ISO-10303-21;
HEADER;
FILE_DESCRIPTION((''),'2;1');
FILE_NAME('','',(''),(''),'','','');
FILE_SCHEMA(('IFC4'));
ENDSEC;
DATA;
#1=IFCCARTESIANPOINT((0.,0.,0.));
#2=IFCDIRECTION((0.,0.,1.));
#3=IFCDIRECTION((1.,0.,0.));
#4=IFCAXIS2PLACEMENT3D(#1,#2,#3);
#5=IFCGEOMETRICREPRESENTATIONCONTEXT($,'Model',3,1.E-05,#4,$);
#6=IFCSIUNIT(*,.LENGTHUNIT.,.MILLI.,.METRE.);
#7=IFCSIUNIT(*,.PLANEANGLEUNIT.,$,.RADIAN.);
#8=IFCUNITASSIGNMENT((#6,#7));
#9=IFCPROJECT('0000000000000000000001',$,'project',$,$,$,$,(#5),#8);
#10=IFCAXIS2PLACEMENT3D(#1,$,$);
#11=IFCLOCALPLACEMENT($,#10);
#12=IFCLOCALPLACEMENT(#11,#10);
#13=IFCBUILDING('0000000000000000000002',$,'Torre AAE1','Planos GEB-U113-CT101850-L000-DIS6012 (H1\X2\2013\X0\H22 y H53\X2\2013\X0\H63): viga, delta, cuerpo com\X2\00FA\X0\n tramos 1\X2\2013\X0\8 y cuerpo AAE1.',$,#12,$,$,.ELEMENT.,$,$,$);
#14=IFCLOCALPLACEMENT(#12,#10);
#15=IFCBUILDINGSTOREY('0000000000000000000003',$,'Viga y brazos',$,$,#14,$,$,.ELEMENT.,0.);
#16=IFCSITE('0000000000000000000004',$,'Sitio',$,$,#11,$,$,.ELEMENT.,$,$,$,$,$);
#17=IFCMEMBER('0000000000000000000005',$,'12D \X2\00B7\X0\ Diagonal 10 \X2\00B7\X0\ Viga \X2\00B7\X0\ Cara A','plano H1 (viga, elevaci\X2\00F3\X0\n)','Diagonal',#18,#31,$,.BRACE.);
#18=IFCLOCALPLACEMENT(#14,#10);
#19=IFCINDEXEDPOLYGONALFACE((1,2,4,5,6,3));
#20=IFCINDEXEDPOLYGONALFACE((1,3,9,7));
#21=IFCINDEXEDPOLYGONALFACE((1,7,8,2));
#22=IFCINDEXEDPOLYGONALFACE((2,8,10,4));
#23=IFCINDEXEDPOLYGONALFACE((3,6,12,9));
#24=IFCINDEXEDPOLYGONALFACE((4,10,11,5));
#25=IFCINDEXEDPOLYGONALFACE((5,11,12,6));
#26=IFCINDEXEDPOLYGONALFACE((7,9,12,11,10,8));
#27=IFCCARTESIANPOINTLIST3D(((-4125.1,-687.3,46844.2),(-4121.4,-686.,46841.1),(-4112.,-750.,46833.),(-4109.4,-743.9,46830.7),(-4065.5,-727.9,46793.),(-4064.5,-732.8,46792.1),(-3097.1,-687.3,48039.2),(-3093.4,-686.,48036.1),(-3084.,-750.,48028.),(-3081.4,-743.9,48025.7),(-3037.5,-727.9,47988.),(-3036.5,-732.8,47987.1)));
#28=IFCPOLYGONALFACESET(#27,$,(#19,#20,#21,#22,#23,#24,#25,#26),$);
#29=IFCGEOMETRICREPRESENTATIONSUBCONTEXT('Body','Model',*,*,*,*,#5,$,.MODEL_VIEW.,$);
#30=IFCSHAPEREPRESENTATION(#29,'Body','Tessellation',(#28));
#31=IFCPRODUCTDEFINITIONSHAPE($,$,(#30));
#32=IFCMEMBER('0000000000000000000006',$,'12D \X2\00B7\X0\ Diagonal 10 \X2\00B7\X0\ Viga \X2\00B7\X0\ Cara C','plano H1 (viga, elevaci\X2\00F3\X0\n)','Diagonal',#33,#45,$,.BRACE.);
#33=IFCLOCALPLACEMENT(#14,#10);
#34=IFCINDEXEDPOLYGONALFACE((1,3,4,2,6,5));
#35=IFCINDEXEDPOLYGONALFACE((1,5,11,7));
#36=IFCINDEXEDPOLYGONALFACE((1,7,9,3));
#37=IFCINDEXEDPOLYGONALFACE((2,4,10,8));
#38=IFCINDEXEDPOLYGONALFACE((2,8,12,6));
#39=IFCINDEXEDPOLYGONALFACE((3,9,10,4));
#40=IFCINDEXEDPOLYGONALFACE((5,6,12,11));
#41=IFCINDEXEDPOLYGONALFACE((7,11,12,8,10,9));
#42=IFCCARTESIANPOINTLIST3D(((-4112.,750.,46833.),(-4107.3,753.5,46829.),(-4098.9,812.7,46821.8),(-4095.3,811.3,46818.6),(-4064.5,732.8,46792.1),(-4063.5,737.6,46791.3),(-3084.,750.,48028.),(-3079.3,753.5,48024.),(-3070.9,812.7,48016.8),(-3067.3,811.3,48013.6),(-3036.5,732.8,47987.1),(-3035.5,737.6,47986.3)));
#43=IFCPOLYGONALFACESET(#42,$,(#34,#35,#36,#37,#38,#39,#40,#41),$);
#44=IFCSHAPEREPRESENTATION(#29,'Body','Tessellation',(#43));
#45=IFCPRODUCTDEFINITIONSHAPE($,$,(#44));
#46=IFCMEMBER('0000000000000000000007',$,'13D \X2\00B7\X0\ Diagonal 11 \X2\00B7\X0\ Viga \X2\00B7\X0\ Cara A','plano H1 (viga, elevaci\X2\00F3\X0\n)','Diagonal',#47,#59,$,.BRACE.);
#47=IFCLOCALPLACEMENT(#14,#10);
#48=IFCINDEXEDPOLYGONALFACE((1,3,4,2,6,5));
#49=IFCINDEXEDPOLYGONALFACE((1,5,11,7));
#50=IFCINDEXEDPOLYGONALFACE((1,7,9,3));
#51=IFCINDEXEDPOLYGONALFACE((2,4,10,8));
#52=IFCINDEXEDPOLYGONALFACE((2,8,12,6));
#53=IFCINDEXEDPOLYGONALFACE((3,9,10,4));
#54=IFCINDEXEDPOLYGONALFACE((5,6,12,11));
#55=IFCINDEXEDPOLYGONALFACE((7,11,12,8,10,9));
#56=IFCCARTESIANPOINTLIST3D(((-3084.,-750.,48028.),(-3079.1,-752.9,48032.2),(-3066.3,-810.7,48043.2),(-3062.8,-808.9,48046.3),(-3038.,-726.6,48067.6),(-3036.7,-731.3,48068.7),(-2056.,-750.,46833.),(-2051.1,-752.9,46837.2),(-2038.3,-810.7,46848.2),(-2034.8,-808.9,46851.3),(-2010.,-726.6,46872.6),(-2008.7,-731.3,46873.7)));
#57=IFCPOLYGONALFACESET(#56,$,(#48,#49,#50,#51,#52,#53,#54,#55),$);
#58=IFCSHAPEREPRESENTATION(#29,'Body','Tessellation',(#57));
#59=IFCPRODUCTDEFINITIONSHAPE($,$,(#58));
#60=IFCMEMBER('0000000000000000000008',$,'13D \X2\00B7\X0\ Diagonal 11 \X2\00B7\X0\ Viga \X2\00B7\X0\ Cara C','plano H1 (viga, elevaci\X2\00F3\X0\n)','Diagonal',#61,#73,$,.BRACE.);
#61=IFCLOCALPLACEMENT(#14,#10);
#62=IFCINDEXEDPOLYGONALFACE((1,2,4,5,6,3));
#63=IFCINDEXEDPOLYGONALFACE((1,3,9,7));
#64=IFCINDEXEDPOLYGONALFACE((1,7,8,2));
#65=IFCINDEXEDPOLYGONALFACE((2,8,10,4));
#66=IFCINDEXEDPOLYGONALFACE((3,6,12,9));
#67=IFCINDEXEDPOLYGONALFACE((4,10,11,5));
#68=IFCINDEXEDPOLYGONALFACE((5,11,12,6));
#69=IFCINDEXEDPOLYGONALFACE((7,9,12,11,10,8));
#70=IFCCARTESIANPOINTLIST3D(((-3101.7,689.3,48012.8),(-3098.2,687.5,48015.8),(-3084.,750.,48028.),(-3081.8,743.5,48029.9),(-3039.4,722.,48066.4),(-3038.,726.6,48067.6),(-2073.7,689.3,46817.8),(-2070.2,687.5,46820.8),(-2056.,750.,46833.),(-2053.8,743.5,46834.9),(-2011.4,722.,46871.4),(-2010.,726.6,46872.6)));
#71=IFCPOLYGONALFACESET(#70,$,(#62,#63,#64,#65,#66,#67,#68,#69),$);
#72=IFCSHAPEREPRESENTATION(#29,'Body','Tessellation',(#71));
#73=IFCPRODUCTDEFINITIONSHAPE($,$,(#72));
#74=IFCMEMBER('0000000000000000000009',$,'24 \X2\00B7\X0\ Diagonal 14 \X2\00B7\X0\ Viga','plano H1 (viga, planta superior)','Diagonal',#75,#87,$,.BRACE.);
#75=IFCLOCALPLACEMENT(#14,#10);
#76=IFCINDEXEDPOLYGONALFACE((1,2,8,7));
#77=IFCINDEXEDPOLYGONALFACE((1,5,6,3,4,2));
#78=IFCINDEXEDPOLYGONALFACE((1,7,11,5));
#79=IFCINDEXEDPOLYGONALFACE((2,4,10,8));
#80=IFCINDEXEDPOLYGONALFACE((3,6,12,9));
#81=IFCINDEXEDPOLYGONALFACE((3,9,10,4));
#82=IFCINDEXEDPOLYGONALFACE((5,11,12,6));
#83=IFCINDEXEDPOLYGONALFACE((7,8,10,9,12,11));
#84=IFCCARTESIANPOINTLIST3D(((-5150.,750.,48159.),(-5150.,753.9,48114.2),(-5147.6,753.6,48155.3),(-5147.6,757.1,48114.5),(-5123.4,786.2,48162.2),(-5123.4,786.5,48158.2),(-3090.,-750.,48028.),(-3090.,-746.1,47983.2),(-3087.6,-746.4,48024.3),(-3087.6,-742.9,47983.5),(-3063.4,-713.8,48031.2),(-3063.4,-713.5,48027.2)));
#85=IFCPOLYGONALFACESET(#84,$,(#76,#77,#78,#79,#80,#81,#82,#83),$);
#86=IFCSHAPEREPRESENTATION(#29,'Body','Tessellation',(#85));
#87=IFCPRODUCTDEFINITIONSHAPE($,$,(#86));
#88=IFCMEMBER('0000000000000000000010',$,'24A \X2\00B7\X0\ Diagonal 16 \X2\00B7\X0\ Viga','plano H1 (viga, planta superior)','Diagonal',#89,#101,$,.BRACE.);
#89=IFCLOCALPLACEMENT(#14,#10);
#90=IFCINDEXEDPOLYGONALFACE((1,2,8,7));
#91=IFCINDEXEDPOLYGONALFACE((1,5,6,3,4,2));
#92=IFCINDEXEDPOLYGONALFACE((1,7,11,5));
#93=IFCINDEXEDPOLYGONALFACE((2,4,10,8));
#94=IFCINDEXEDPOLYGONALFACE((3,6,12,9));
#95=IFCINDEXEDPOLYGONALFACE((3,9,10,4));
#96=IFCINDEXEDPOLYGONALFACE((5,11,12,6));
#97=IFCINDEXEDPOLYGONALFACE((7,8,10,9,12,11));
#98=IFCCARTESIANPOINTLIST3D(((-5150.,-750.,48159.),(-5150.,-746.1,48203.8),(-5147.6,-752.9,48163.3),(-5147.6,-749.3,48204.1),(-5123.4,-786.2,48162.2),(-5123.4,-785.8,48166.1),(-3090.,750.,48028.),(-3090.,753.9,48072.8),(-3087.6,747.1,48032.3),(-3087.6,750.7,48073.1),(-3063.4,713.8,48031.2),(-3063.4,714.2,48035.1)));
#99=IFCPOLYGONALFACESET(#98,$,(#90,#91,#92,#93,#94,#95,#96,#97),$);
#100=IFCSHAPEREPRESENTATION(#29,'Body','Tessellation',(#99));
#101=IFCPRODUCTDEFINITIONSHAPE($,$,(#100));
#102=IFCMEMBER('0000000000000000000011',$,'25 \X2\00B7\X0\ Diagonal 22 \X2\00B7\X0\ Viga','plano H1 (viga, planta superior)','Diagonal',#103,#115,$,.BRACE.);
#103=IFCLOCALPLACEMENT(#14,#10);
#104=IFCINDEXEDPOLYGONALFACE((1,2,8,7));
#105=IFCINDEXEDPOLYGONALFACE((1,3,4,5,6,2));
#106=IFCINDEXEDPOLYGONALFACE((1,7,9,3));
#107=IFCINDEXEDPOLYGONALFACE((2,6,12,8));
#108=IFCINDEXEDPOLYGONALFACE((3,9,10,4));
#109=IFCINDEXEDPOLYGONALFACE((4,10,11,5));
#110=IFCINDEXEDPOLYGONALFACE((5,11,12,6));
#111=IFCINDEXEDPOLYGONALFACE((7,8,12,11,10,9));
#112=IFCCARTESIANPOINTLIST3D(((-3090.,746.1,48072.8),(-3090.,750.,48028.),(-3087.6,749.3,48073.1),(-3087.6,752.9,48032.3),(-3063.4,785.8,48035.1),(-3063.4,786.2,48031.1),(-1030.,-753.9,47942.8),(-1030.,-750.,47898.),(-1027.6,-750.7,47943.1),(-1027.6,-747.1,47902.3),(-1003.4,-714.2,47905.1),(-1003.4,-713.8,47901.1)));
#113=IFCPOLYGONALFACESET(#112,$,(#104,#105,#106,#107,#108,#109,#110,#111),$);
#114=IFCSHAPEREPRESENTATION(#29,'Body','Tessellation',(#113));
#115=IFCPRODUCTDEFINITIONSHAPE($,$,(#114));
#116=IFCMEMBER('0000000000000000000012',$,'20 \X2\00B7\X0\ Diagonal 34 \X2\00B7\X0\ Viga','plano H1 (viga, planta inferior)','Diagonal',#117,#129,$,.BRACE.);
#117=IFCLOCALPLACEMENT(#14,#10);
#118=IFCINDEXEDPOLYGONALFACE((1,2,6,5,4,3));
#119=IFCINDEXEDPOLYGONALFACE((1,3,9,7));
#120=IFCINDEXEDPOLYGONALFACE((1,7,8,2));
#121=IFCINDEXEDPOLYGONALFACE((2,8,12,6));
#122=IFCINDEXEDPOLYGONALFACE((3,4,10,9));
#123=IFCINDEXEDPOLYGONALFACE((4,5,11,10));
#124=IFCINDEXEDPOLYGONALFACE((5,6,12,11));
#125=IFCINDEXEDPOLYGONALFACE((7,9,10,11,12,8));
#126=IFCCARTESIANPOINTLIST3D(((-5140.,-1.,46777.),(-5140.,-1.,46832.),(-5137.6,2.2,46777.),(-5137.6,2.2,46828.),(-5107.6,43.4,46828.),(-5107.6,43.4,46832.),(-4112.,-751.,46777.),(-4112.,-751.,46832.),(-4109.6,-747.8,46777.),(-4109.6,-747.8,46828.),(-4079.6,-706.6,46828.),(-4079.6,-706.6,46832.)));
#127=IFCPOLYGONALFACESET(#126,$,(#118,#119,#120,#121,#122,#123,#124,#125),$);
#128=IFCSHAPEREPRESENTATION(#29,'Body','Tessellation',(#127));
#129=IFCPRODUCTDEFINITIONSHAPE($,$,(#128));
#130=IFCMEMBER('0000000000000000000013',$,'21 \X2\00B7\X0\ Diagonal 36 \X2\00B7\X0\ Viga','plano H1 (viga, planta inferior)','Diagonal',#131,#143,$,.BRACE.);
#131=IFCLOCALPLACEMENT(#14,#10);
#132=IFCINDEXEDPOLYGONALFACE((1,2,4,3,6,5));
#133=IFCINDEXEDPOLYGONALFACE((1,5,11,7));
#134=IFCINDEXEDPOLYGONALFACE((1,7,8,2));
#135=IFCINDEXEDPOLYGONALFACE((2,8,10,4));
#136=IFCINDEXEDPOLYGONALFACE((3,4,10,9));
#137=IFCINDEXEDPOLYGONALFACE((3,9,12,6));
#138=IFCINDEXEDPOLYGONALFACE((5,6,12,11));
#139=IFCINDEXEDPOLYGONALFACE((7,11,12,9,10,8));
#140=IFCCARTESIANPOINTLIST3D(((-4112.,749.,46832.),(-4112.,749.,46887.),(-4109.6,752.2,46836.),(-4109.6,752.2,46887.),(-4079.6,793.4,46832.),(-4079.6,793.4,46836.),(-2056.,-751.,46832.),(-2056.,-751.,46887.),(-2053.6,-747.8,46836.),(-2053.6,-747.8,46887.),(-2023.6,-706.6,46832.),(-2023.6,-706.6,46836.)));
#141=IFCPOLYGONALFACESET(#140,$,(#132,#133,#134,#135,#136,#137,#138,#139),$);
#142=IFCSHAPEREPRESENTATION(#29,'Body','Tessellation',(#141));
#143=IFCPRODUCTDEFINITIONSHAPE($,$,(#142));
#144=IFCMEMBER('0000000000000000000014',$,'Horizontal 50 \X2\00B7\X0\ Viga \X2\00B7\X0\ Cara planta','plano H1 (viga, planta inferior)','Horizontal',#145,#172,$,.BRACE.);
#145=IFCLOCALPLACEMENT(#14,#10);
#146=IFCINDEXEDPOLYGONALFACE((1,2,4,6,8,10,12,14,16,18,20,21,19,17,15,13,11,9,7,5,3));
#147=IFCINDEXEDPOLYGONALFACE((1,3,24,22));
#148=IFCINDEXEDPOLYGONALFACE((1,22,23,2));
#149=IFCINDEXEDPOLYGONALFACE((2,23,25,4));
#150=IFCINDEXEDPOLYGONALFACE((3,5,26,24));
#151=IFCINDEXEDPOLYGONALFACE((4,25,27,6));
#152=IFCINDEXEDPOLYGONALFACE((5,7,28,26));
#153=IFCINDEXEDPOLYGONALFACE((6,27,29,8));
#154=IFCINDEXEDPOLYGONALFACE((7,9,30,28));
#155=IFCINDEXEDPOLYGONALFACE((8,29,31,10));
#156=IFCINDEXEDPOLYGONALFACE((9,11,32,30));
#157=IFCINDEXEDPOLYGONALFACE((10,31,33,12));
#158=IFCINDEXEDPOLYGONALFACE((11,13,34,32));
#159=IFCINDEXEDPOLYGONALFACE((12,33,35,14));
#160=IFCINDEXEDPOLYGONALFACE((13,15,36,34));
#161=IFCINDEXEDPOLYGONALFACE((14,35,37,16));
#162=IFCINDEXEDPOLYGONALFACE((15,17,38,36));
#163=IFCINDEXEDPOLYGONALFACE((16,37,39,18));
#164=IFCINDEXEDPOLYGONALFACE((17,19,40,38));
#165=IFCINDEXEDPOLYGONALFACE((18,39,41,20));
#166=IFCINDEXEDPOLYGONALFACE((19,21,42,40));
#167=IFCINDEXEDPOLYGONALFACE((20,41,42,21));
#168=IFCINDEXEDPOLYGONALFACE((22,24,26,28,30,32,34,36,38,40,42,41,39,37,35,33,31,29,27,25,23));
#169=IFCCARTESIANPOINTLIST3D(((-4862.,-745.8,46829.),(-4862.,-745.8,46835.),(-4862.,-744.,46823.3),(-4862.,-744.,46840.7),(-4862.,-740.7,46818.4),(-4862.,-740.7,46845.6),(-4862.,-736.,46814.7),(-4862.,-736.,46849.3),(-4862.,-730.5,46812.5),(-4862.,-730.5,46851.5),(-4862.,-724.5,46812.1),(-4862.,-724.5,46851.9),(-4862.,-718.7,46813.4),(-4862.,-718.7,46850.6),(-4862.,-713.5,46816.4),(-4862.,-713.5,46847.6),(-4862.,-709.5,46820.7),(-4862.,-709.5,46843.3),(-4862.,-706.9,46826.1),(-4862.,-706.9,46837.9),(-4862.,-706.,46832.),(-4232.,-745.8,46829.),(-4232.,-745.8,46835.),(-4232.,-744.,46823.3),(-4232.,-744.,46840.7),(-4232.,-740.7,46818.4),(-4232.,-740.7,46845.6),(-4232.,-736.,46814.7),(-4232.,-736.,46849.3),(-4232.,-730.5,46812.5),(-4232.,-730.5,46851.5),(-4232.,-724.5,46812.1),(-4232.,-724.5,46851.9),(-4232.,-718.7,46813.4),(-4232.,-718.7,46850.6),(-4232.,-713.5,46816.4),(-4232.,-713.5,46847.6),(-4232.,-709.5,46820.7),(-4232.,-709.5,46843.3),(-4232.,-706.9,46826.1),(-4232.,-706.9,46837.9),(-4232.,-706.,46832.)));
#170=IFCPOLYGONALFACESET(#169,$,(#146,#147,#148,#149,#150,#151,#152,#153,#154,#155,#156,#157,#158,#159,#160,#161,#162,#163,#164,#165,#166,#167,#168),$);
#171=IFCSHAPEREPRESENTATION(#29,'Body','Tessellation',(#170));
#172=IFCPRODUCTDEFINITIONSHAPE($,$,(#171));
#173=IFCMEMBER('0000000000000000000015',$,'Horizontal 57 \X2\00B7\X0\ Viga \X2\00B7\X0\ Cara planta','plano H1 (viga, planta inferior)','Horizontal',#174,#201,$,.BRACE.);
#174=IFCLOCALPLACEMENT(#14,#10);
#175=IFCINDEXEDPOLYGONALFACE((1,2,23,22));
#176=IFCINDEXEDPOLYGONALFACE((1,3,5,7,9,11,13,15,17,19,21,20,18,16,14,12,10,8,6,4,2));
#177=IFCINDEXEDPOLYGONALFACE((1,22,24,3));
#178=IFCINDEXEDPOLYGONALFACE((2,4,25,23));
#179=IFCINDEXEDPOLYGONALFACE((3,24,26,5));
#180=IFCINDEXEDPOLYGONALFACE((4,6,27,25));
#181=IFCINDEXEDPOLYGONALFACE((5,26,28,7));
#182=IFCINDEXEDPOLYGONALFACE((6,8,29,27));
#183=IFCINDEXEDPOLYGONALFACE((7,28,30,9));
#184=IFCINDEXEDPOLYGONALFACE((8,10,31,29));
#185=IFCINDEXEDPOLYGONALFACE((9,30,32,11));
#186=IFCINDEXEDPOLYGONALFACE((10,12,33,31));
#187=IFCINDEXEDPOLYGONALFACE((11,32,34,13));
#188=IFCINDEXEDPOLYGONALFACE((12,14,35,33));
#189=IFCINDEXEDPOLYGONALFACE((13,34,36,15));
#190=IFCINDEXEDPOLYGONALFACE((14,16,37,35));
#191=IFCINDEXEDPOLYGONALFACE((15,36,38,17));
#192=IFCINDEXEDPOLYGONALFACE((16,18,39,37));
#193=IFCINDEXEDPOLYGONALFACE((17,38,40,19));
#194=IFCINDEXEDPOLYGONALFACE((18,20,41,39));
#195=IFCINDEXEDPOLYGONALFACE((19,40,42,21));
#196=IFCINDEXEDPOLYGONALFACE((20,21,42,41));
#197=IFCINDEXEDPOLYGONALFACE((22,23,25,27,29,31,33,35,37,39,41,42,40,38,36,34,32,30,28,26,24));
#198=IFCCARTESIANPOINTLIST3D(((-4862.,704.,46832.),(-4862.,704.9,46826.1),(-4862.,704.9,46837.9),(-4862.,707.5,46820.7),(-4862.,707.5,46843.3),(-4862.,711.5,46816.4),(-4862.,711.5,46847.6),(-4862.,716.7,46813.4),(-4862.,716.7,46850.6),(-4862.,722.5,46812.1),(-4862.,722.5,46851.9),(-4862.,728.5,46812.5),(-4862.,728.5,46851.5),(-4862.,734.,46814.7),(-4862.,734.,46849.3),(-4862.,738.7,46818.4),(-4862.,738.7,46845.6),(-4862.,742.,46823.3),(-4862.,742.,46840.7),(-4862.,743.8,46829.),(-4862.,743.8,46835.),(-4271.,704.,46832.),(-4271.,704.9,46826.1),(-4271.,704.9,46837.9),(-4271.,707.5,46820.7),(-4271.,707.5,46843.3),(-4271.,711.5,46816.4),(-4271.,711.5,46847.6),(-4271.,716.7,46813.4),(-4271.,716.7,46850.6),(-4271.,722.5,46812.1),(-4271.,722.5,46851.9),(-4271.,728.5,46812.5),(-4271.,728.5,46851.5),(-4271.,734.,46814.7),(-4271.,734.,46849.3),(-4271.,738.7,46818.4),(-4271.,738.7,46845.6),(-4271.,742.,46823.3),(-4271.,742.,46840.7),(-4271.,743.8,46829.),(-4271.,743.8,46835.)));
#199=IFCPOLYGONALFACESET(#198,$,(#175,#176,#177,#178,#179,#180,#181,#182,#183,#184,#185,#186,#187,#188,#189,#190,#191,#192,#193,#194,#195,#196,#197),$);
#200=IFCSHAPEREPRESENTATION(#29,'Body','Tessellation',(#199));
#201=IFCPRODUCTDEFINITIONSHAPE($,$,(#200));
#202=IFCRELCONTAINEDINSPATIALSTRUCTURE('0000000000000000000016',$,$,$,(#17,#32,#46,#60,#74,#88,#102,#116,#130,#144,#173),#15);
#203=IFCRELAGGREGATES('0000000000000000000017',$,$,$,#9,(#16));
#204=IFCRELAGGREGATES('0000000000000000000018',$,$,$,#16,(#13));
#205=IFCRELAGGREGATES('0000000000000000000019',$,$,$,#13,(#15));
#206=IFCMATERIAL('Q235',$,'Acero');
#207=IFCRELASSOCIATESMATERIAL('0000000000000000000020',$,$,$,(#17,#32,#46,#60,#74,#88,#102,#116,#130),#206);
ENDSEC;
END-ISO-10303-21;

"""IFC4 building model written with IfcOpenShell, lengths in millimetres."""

from ifc_helpers import new_model, si_unit, frame, frame_2d, origin, origin_with_axes, place, context, subcontext, project, spatial, circle, l_section, extrude, material, element, save


model = new_model("IFC4")

# Units and contexts
model_context = context("Model", 3, precision=1e-05, world=origin_with_axes())
body_context = subcontext(model_context, "Body", "Model", "MODEL_VIEW")
ifc_project = project(units=[si_unit("LENGTHUNIT", "METRE", prefix="MILLI"), si_unit("PLANEANGLEUNIT", "RADIAN")], contexts=[model_context])

# Site, building, storey
site_placement = place(None, origin())
site = spatial("IfcSite", under=ifc_project, at=site_placement, Name="Sitio", CompositionType="ELEMENT")
building_placement = place(site_placement, origin())
building = spatial("IfcBuilding", under=site, at=building_placement, Name="Torre AAE1", Description="Planos GEB-U113-CT101850-L000-DIS6012 (H1–H22 y H53–H63): viga, delta, cuerpo común tramos 1–8 y cuerpo AAE1.", CompositionType="ELEMENT")
storey_placement = place(building_placement, origin())
storey = spatial("IfcBuildingStorey", under=building, at=storey_placement, Name="Viga y brazos", CompositionType="ELEMENT", Elevation=0.0)

# Members
ifc_material = material(Name="Q235", Category="Acero")
for number, where, z_axis, x_axis, name in (
    (1, (-4112.0, -750.0, 46833.0), (0.652149, 0.0, 0.758091), (0.730962, 0.265126, -0.628811), "12D · Diagonal 10 · Viga · Cara A"),
    (2, (-4112.0, 750.0, 46833.0), (0.652149, 0.0, 0.758091), (0.730962, -0.265126, -0.628811), "12D · Diagonal 10 · Viga · Cara C"),
    (3, (-3084.0, -750.0, 48028.0), (0.652149, 0.0, -0.758091), (0.707481, 0.359253, 0.608611), "13D · Diagonal 11 · Viga · Cara A"),
    (4, (-3084.0, 750.0, 48028.0), (0.652149, 0.0, -0.758091), (0.707481, -0.359253, 0.608611), "13D · Diagonal 11 · Viga · Cara C"),
):
    element("IfcMember", number, at=place(storey_placement, frame(where, z_axis=z_axis, x_axis=x_axis)), inside=storey, material=ifc_material, Name=name, Description="plano H1 (viga, elevación)", ObjectType="Diagonal", PredefinedType="BRACE", context=body_context, shape_type="SweptSolid", body=[
        extrude(l_section(Depth=65.0, Width=65.0, Thickness=5.0, at=frame_2d((32.5, 32.5))), None, (0.0, 0.0, 1.0), 1576.3),
    ])
for number, where, z_axis, x_axis, name in (
    (5, (-3090.0, -750.0, 48028.0), (-0.80733, 0.587862, 0.05134), (0.5901, 0.804269, 0.07024), "24 · Diagonal 14 · Viga"),
    (6, (-3090.0, 750.0, 48028.0), (-0.80733, -0.587862, 0.05134), (0.5901, -0.804269, 0.07024), "24A · Diagonal 16 · Viga"),
):
    element("IfcMember", number, at=place(storey_placement, frame(where, z_axis=z_axis, x_axis=x_axis)), inside=storey, material=ifc_material, Name=name, Description="plano H1 (viga, planta superior)", ObjectType="Diagonal", PredefinedType="BRACE", context=body_context, shape_type="SweptSolid", body=[
        extrude(l_section(Depth=45.0, Width=45.0, Thickness=4.0, at=frame_2d((22.5, 22.5))), None, (0.0, 0.0, 1.0), 2551.6),
    ])
member_1_placement = place(storey_placement, frame((-3090.0, 750.0, 48028.0), z_axis=(0.807347, -0.587874, -0.050949), x_axis=(0.590077, 0.804332, 0.069709)))
element("IfcMember", 7, at=member_1_placement, inside=storey, material=ifc_material, Name="25 · Diagonal 22 · Viga", Description="plano H1 (viga, planta superior)", ObjectType="Diagonal", PredefinedType="BRACE", context=body_context, shape_type="SweptSolid", body=[
    extrude(l_section(Depth=45.0, Width=45.0, Thickness=4.0, at=frame_2d((22.5, 22.5))), None, (0.0, 0.0, 1.0), 2551.6),
])
member_2_placement = place(storey_placement, frame((-4112.0, -751.0, 46832.0), z_axis=(-0.807852, 0.589386, 0.0), x_axis=(0.589386, 0.807852, 0.0)))
element("IfcMember", 8, at=member_2_placement, inside=storey, material=ifc_material, Name="20 · Diagonal 34 · Viga", Description="plano H1 (viga, planta inferior)", ObjectType="Diagonal", PredefinedType="BRACE", context=body_context, shape_type="SweptSolid", body=[
    extrude(l_section(Depth=55.0, Width=55.0, Thickness=4.0, at=frame_2d((27.5, 27.5))), None, (0.0, 0.0, 1.0), 1272.5),
])
member_3_placement = place(storey_placement, frame((-4112.0, 749.0, 46832.0), z_axis=(0.807852, -0.589386, 0.0), x_axis=(0.589386, 0.807852, 0.0)))
element("IfcMember", 9, at=member_3_placement, inside=storey, material=ifc_material, Name="21 · Diagonal 36 · Viga", Description="plano H1 (viga, planta inferior)", ObjectType="Diagonal", PredefinedType="BRACE", context=body_context, shape_type="SweptSolid", body=[
    extrude(l_section(Depth=55.0, Width=55.0, Thickness=4.0, at=frame_2d((27.5, 27.5))), None, (0.0, 0.0, 1.0), 2545.0),
])
member_4_placement = place(storey_placement, frame((-4232.0, -726.0, 46832.0), z_axis=(-1.0, 0.0, 0.0), x_axis=(0.0, 1.0, 0.0)))
element("IfcMember", 10, at=member_4_placement, inside=storey, Name="Horizontal 50 · Viga · Cara planta", Description="plano H1 (viga, planta inferior)", ObjectType="Horizontal", PredefinedType="BRACE", context=body_context, shape_type="SweptSolid", body=[
    extrude(circle(Radius=20.0), None, (0.0, 0.0, 1.0), 630.0),
])
member_5_placement = place(storey_placement, frame((-4271.0, 724.0, 46832.0), z_axis=(-1.0, 0.0, 0.0), x_axis=(0.0, -1.0, 0.0)))
element("IfcMember", 11, at=member_5_placement, inside=storey, Name="Horizontal 57 · Viga · Cara planta", Description="plano H1 (viga, planta inferior)", ObjectType="Horizontal", PredefinedType="BRACE", context=body_context, shape_type="SweptSolid", body=[
    extrude(circle(Radius=20.0), None, (0.0, 0.0, 1.0), 591.0),
])

save(model, "model.ifc")
